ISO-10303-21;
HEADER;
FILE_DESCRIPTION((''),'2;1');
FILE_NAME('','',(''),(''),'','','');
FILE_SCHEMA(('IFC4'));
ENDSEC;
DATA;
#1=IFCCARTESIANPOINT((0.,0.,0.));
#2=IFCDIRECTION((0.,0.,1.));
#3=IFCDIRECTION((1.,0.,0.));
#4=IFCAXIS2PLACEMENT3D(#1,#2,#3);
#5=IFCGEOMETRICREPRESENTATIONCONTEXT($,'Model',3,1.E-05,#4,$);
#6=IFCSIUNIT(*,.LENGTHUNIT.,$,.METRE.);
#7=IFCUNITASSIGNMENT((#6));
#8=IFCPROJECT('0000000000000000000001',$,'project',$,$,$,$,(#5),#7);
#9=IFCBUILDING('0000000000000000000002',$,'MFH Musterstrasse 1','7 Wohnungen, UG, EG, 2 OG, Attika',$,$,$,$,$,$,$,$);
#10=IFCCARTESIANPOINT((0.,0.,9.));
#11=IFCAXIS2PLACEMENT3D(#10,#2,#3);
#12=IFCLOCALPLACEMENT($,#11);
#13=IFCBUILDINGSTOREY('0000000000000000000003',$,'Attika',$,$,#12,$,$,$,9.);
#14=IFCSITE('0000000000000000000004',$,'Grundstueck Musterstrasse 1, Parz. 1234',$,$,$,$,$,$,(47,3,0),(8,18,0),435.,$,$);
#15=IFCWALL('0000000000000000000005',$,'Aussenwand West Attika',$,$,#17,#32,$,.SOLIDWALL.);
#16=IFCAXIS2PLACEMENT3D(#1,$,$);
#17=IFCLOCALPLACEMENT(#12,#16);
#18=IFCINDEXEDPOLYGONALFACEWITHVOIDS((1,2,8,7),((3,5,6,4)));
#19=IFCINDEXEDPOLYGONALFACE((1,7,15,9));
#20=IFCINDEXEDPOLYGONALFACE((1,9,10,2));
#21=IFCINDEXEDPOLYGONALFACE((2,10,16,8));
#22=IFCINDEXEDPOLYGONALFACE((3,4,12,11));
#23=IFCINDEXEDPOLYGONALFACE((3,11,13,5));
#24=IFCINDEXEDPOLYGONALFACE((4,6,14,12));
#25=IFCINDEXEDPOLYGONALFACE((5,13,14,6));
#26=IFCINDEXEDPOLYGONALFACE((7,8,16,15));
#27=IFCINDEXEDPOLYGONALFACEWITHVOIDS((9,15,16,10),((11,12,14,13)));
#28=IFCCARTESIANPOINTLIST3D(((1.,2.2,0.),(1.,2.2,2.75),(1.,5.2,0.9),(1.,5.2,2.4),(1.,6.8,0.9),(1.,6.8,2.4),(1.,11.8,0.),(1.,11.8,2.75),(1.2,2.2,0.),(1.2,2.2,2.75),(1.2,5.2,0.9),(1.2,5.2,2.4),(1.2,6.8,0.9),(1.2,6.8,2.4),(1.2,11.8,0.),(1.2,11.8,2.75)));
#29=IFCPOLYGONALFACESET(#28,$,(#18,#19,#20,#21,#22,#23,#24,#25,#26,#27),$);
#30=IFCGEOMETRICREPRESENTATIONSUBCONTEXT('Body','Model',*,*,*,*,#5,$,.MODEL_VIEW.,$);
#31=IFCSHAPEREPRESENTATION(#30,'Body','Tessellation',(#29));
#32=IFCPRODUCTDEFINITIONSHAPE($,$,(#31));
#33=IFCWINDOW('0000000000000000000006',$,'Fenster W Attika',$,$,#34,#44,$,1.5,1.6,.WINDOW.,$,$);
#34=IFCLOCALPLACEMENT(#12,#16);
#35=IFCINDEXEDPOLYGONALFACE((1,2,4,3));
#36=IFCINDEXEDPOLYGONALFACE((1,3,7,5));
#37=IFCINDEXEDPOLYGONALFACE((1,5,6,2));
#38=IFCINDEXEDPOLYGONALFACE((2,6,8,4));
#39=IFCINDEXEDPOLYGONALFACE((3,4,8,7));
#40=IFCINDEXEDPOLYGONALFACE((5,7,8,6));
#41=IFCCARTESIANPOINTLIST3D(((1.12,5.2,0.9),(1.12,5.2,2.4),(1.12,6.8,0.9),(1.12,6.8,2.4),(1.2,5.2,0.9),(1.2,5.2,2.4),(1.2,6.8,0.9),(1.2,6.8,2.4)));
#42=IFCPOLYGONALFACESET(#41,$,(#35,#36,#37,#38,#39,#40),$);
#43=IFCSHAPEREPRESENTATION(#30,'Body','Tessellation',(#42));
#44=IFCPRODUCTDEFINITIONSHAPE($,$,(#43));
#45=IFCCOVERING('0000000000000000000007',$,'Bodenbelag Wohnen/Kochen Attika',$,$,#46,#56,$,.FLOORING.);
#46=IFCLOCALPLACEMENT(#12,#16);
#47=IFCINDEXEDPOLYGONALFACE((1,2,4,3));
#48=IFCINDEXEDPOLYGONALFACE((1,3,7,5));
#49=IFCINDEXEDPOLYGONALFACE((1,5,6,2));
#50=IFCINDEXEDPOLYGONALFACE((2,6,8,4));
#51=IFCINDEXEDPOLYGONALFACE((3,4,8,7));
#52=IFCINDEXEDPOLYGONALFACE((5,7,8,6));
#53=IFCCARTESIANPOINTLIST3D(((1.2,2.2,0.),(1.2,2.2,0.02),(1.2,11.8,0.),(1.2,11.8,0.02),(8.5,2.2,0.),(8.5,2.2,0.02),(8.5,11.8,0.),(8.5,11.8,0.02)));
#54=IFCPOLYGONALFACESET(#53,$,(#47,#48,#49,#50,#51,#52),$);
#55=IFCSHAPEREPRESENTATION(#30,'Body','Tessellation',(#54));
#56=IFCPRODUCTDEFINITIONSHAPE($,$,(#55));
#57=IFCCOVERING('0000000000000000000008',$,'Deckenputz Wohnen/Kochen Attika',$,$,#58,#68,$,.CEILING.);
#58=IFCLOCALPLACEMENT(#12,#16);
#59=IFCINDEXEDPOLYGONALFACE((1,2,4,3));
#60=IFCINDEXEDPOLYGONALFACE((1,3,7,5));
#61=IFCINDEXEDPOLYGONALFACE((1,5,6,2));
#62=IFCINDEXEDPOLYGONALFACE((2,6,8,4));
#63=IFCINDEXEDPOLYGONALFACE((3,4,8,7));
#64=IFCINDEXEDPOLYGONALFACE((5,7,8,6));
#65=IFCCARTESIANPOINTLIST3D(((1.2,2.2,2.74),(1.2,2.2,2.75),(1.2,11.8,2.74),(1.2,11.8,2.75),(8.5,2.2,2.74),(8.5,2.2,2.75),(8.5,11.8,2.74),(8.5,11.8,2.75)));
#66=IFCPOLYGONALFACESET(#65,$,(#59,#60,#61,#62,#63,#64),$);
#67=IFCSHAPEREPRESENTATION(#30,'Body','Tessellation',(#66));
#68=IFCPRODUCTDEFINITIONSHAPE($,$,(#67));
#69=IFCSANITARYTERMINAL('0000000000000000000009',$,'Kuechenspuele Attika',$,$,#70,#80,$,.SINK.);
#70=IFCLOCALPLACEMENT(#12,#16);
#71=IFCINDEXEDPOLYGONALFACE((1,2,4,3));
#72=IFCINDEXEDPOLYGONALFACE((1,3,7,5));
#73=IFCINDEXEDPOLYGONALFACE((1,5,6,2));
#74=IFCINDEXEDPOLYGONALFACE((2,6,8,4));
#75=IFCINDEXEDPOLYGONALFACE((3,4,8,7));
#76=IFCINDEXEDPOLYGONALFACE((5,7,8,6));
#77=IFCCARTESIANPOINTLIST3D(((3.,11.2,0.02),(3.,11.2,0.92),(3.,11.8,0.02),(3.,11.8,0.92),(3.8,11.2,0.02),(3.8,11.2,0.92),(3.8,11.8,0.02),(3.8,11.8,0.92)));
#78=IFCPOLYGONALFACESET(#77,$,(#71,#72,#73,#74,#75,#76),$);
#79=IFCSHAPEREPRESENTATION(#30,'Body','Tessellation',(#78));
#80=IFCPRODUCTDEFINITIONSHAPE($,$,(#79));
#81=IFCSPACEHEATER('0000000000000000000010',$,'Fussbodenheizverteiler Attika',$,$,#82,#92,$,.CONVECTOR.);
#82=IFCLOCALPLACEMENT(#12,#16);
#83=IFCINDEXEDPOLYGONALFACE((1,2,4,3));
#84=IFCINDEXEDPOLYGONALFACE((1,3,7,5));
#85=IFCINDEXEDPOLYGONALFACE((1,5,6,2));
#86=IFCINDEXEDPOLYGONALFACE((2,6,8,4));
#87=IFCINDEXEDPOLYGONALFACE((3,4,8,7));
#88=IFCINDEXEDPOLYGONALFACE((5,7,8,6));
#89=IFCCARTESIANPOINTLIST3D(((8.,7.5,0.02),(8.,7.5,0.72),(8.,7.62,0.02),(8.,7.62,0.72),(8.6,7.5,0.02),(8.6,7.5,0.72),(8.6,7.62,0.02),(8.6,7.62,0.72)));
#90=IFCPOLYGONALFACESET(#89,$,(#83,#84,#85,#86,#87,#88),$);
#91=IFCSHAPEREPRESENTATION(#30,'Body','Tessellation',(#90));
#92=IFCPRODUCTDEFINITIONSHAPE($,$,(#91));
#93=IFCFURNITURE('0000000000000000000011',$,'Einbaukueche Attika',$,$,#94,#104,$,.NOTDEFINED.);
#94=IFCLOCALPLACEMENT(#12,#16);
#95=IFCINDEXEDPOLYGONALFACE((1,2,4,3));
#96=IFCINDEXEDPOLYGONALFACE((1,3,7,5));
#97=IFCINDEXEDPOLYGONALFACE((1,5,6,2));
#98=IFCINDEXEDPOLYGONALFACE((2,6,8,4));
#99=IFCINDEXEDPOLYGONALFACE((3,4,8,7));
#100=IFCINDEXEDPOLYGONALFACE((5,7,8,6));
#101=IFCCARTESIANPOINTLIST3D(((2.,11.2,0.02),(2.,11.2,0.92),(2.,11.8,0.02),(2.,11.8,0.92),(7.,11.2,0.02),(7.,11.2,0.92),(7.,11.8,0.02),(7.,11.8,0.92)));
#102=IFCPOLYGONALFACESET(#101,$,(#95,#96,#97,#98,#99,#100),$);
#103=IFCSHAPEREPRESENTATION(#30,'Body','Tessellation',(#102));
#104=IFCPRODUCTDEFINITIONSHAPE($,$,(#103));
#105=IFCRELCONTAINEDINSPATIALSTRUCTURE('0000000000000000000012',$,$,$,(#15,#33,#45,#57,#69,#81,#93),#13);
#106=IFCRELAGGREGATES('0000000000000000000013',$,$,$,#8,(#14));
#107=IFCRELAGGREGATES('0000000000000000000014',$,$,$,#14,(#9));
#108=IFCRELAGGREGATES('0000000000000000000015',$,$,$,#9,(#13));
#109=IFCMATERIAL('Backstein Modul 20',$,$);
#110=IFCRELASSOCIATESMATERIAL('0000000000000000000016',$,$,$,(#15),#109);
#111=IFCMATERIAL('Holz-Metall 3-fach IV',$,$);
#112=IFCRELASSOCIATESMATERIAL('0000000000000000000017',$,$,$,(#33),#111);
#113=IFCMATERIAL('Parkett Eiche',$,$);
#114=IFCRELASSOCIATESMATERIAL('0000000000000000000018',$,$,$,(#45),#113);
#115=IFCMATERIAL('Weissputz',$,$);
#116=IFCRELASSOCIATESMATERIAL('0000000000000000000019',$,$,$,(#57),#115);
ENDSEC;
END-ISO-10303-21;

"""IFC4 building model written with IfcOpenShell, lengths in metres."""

from ifc_helpers import new_model, si_unit, frame, frame_2d, origin_with_axes, place, context, subcontext, project, spatial, rectangle, extrude, material, element, fill, save


model = new_model("IFC4")

# Units and contexts
model_context = context("Model", 3, precision=1e-05, world=origin_with_axes())
body_context = subcontext(model_context, "Body", "Model", "MODEL_VIEW")
ifc_project = project(units=[si_unit("LENGTHUNIT", "METRE")], contexts=[model_context])

# Site, building, storey
site = spatial("IfcSite", under=ifc_project, Name="Grundstueck Musterstrasse 1, Parz. 1234", RefLatitude=(47, 3, 0), RefLongitude=(8, 18, 0), RefElevation=435.0)
building = spatial("IfcBuilding", under=site, Name="MFH Musterstrasse 1", Description="7 Wohnungen, UG, EG, 2 OG, Attika")
storey_placement = place(None, frame((0.0, 0.0, 9.0), z_axis=(0.0, 0.0, 1.0), x_axis=(1.0, 0.0, 0.0)))
storey = spatial("IfcBuildingStorey", under=building, at=storey_placement, Name="Attika", Elevation=9.0)

# Shared definitions
ifc_material_1 = material(Name="Backstein Modul 20")
ifc_material_2 = material(Name="Holz-Metall 3-fach IV")

# Wall, opening, window
wall_1_placement = place(storey_placement, frame((1.0, 2.2, 0.0), z_axis=(0.0, 0.0, 1.0), x_axis=(1.0, 0.0, 0.0)))
wall_1 = element("IfcWall", 1, at=wall_1_placement, inside=storey, material=ifc_material_1, Name="Aussenwand West Attika", PredefinedType="SOLIDWALL", context=body_context, shape_type="SweptSolid", body=[
    extrude(rectangle(XDim=0.2, YDim=9.6, at=frame_2d((0.1, 4.8))), origin_with_axes(), (0.0, 0.0, 1.0), 2.75),
])
opening_1_placement = place(wall_1_placement, frame((-0.21, 3.0, 0.9), z_axis=(0.0, 0.0, 1.0), x_axis=(1.0, 0.0, 0.0)))
opening_1 = element("IfcOpeningElement", 2, at=opening_1_placement, cuts=wall_1, context=body_context, shape_type="SweptSolid", body=[
    extrude(rectangle(XDim=0.42, YDim=1.6, at=frame_2d((0.21, 0.8))), origin_with_axes(), (0.0, 0.0, 1.0), 1.5),
])
window_1_placement = place(storey_placement, frame((1.12, 5.2, 0.9), z_axis=(0.0, 0.0, 1.0), x_axis=(1.0, 0.0, 0.0)))
window_1 = element("IfcWindow", 3, at=window_1_placement, inside=storey, material=ifc_material_2, Name="Fenster W Attika", OverallHeight=1.5, OverallWidth=1.6, PredefinedType="WINDOW", context=body_context, shape_type="SweptSolid", body=[
    extrude(rectangle(XDim=0.08, YDim=1.6, at=frame_2d((0.04, 0.8))), origin_with_axes(), (0.0, 0.0, 1.0), 1.5),
])
fill(opening_1, window_1)

# Coverings
ifc_material_3 = material(Name="Parkett Eiche")
covering_1_placement = place(storey_placement, frame((1.2, 2.2, 0.0), z_axis=(0.0, 0.0, 1.0), x_axis=(1.0, 0.0, 0.0)))
element("IfcCovering", 4, at=covering_1_placement, inside=storey, material=ifc_material_3, Name="Bodenbelag Wohnen/Kochen Attika", PredefinedType="FLOORING", context=body_context, shape_type="SweptSolid", body=[
    extrude(rectangle(XDim=7.3, YDim=9.6, at=frame_2d((3.65, 4.8))), origin_with_axes(), (0.0, 0.0, 1.0), 0.02),
])
ifc_material_4 = material(Name="Weissputz")
covering_2_placement = place(storey_placement, frame((1.2, 2.2, 2.74), z_axis=(0.0, 0.0, 1.0), x_axis=(1.0, 0.0, 0.0)))
element("IfcCovering", 5, at=covering_2_placement, inside=storey, material=ifc_material_4, Name="Deckenputz Wohnen/Kochen Attika", PredefinedType="CEILING", context=body_context, shape_type="SweptSolid", body=[
    extrude(rectangle(XDim=7.3, YDim=9.6, at=frame_2d((3.65, 4.8))), origin_with_axes(), (0.0, 0.0, 1.0), 0.01),
])

# Sanitary terminal
sanitary_terminal_placement = place(storey_placement, frame((3.0, 11.2, 0.02), z_axis=(0.0, 0.0, 1.0), x_axis=(1.0, 0.0, 0.0)))
element("IfcSanitaryTerminal", 6, at=sanitary_terminal_placement, inside=storey, Name="Kuechenspuele Attika", PredefinedType="SINK", context=body_context, shape_type="SweptSolid", body=[
    extrude(rectangle(XDim=0.8, YDim=0.6, at=frame_2d((0.4, 0.3))), origin_with_axes(), (0.0, 0.0, 1.0), 0.9),
])

# Space heater
space_heater_placement = place(storey_placement, frame((8.0, 7.5, 0.02), z_axis=(0.0, 0.0, 1.0), x_axis=(1.0, 0.0, 0.0)))
element("IfcSpaceHeater", 7, at=space_heater_placement, inside=storey, Name="Fussbodenheizverteiler Attika", PredefinedType="CONVECTOR", context=body_context, shape_type="SweptSolid", body=[
    extrude(rectangle(XDim=0.6, YDim=0.12, at=frame_2d((0.3, 0.06))), origin_with_axes(), (0.0, 0.0, 1.0), 0.7),
])

# Furniture
furniture_placement = place(storey_placement, frame((2.0, 11.2, 0.02), z_axis=(0.0, 0.0, 1.0), x_axis=(1.0, 0.0, 0.0)))
element("IfcFurniture", 8, at=furniture_placement, inside=storey, Name="Einbaukueche Attika", PredefinedType="NOTDEFINED", context=body_context, shape_type="SweptSolid", body=[
    extrude(rectangle(XDim=5.0, YDim=0.6, at=frame_2d((2.5, 0.3))), origin_with_axes(), (0.0, 0.0, 1.0), 0.9),
])

save(model, "model.ifc")
